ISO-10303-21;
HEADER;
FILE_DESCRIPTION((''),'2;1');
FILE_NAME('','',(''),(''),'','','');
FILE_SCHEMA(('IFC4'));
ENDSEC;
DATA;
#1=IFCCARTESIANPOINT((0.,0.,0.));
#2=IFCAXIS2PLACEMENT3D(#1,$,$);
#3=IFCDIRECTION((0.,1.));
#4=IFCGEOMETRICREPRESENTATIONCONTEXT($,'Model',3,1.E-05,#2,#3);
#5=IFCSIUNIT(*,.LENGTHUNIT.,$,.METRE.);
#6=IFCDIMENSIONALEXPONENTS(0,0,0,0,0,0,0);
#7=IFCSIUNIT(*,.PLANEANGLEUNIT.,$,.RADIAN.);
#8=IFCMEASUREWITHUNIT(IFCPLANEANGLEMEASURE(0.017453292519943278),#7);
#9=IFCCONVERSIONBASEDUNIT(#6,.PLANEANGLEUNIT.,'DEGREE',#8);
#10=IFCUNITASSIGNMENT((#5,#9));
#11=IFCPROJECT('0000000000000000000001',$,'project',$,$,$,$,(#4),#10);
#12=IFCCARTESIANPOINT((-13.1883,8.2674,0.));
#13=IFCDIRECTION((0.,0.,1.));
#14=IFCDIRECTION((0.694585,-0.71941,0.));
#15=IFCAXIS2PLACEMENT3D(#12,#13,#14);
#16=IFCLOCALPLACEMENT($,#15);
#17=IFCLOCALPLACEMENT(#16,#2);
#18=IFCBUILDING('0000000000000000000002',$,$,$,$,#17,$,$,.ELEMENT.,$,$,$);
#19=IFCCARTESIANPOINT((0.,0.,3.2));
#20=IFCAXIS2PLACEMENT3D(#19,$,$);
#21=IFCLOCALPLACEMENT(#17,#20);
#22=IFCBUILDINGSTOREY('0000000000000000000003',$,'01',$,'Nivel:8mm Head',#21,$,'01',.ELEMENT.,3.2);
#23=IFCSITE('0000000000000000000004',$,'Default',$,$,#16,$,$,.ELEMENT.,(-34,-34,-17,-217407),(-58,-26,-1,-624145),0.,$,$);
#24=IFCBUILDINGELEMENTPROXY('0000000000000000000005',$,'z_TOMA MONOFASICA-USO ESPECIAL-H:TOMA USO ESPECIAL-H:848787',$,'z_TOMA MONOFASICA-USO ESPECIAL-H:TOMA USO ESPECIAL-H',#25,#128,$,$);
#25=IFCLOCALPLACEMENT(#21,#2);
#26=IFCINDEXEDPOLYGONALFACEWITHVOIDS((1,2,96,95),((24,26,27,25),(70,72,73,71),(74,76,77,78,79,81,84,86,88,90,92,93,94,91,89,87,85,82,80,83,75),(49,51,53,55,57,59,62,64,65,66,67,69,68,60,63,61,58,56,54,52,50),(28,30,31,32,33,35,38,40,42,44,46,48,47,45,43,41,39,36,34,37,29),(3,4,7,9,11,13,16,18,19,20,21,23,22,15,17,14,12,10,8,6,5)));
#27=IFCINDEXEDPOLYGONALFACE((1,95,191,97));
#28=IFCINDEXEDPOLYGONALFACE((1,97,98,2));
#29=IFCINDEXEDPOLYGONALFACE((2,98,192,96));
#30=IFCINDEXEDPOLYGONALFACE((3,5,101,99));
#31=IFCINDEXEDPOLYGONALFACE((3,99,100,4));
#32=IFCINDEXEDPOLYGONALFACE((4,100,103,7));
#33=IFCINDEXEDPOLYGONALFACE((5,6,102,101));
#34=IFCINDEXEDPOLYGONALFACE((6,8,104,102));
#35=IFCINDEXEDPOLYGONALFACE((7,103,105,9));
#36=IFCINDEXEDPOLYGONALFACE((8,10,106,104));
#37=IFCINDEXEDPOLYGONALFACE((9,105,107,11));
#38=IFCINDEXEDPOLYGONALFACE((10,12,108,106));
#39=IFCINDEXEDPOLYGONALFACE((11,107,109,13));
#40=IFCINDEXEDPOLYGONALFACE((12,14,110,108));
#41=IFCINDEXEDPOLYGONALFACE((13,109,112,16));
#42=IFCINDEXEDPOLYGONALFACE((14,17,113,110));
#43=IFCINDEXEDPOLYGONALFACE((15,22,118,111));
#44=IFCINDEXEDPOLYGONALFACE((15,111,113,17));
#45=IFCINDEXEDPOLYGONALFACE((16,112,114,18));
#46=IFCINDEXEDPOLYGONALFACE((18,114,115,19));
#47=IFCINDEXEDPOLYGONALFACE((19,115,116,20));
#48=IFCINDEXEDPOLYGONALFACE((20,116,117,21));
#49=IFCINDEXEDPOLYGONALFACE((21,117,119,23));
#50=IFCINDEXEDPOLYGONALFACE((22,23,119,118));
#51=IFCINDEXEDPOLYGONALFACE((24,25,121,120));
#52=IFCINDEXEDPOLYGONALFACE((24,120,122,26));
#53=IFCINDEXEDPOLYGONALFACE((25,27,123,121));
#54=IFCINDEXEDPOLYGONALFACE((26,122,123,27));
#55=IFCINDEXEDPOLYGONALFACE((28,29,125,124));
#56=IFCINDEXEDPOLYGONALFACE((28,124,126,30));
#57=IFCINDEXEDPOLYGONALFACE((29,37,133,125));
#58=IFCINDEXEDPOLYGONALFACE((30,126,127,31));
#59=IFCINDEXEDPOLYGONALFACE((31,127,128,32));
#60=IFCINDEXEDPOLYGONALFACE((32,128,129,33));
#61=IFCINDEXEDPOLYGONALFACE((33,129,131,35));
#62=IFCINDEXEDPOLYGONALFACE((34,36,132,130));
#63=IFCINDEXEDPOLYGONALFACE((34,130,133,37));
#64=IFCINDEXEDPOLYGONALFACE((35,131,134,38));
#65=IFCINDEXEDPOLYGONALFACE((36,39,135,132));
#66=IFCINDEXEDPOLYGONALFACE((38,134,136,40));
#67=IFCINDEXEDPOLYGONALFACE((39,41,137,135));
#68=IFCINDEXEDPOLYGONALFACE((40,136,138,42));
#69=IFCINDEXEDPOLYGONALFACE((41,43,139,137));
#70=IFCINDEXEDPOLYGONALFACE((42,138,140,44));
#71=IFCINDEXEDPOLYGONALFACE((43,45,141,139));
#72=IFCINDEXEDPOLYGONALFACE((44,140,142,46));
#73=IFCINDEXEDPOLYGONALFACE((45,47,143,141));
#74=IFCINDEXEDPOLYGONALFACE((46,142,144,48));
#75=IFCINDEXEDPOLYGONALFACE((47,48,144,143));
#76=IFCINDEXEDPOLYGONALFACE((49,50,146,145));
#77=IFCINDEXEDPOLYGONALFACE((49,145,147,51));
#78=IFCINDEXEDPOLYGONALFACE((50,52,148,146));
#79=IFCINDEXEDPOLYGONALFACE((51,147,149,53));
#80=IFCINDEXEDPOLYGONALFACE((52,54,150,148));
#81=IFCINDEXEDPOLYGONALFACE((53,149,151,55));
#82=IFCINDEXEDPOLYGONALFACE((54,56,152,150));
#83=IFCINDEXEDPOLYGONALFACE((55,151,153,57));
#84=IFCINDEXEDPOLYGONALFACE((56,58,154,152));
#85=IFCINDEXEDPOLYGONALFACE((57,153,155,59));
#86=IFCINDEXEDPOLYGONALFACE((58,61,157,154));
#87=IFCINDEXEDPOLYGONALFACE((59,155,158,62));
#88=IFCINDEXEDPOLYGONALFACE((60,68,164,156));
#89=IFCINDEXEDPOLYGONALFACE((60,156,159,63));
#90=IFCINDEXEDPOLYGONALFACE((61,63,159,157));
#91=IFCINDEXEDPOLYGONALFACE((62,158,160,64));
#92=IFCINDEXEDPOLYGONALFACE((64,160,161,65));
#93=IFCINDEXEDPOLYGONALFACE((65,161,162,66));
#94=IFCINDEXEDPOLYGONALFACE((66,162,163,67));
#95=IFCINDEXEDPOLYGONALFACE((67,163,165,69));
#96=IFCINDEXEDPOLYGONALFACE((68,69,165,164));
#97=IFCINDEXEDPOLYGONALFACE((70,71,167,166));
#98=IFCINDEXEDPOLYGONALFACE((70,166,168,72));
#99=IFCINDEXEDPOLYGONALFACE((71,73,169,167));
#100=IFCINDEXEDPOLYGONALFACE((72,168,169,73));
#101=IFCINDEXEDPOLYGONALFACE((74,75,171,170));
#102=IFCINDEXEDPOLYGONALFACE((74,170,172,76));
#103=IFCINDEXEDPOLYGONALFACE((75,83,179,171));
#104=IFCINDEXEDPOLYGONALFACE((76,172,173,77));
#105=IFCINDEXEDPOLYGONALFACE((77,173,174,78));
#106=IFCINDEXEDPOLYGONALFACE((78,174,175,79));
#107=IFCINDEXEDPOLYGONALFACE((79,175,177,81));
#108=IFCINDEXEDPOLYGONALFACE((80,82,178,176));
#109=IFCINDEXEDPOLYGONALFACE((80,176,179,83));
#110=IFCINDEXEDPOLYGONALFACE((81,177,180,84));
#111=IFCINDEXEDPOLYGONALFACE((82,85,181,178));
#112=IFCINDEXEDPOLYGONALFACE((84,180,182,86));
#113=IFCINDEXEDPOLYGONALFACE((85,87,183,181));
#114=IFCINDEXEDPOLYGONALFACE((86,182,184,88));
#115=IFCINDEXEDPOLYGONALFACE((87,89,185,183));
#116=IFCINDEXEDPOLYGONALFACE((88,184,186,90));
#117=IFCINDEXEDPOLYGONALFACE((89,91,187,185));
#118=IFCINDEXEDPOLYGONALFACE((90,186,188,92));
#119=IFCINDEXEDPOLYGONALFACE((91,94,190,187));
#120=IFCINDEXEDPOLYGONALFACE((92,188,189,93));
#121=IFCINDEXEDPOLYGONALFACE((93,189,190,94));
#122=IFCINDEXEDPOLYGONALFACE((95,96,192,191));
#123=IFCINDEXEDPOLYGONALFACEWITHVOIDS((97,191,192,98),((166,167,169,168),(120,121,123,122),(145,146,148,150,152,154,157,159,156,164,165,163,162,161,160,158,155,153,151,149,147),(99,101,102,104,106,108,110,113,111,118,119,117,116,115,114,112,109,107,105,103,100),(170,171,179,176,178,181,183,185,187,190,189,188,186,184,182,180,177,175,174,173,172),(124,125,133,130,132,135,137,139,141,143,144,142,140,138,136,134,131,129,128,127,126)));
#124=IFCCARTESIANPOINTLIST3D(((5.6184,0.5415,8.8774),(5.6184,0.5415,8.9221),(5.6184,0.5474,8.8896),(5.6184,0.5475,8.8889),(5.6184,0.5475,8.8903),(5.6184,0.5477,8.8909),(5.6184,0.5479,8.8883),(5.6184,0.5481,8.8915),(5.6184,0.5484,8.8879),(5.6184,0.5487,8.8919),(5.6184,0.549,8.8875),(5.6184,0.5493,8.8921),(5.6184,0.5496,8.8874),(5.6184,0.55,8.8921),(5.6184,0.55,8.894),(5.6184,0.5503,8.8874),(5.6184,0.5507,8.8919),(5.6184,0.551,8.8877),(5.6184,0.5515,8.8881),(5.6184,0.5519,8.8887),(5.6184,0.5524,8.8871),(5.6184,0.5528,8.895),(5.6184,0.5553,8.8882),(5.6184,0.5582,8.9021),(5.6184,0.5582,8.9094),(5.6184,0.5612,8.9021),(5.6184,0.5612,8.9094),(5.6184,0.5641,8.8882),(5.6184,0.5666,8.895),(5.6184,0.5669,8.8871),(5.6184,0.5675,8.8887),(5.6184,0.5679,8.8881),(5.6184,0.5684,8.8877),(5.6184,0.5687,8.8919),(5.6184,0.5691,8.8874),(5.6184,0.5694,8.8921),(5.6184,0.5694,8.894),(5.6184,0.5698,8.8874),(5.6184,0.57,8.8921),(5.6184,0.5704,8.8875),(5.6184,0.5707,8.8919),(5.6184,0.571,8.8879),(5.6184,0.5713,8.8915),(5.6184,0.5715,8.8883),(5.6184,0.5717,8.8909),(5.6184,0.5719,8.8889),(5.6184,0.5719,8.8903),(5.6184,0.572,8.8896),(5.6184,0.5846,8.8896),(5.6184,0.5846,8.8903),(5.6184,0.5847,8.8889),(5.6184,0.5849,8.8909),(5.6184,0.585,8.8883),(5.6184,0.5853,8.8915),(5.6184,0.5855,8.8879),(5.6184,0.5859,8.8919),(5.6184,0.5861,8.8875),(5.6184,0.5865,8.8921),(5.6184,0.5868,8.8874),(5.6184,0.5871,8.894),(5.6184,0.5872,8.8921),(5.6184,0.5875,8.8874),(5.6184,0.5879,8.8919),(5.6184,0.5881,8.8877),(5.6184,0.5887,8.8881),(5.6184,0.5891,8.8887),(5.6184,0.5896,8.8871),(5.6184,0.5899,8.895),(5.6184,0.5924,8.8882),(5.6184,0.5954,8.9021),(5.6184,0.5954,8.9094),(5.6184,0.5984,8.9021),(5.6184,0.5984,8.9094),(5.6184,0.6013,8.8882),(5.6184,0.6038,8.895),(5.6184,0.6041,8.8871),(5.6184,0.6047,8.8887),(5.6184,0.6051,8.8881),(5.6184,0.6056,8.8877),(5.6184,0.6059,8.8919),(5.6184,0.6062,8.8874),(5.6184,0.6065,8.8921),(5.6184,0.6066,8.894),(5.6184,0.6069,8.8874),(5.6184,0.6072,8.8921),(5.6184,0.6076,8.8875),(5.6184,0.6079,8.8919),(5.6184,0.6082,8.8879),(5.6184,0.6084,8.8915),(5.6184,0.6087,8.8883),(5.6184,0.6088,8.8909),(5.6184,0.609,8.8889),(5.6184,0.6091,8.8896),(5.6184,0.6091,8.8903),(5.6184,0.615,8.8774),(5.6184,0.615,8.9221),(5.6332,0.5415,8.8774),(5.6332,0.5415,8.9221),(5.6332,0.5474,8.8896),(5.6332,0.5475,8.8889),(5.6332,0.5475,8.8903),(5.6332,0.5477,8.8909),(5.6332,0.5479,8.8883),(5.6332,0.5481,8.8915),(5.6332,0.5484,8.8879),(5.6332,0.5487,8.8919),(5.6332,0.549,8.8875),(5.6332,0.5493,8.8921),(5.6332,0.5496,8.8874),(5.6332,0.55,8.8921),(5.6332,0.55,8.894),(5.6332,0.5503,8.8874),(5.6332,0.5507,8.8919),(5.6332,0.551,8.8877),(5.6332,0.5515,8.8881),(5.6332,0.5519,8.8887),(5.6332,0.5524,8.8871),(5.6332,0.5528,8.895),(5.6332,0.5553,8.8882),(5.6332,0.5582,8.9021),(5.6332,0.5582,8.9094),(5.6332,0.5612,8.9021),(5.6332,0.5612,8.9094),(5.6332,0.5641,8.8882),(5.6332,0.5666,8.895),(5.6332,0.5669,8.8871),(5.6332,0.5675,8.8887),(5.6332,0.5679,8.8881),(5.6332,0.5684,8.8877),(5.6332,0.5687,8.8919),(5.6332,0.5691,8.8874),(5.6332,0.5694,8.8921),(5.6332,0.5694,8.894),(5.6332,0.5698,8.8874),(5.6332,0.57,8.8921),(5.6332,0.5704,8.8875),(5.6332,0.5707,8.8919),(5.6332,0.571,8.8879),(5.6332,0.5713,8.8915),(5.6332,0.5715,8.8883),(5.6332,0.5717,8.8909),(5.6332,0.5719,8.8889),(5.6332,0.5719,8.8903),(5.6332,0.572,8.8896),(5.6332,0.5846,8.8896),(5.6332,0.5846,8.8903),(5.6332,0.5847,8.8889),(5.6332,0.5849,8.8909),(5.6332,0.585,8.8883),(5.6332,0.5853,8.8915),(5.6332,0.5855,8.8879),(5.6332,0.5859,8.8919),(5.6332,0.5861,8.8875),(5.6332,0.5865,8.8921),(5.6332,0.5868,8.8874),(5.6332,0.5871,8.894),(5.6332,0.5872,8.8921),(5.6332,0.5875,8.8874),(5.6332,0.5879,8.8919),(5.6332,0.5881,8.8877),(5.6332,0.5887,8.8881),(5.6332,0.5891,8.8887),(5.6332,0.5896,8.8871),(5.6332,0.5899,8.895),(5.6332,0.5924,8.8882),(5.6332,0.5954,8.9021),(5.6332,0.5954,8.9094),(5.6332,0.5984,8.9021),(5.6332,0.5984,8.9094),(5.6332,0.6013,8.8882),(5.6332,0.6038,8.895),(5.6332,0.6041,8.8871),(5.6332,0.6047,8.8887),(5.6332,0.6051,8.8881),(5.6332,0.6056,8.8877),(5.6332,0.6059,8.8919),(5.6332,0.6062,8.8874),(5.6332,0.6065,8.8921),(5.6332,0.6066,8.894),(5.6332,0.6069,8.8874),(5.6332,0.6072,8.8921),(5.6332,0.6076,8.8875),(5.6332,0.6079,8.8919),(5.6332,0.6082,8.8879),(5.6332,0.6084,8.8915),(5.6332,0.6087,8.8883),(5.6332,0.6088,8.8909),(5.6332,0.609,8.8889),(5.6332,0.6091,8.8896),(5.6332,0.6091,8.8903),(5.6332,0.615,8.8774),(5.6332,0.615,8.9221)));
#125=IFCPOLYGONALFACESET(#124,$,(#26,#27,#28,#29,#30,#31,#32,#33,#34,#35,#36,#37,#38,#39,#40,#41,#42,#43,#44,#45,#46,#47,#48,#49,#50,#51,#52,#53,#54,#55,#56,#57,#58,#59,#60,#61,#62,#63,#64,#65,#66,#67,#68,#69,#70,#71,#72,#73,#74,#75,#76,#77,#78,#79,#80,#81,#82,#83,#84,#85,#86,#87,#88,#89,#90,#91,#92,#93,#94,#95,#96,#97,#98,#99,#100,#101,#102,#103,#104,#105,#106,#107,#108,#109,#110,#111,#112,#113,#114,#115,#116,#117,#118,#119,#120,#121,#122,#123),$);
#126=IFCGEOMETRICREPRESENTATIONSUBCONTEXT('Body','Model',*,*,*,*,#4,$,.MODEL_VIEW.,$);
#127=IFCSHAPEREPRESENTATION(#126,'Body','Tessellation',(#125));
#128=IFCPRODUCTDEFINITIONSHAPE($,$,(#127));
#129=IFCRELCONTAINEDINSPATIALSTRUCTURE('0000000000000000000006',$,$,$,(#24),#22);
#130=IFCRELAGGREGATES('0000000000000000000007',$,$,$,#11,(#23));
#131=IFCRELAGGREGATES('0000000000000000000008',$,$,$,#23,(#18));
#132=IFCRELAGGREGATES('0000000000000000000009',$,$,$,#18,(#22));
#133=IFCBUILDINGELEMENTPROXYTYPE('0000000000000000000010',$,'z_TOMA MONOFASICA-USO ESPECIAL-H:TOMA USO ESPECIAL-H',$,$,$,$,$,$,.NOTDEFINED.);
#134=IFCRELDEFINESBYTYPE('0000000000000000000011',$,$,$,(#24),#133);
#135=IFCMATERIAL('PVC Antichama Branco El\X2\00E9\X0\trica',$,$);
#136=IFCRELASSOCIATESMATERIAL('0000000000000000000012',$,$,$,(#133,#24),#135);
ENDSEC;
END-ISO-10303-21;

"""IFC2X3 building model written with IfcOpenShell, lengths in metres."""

from ifc_helpers import new_model, entity, si_unit, converted_unit, direction, frame, frame_2d, origin, place, context, subcontext, project, spatial, polyline, circle_curve, parameter, trimmed, segment, composite_curve, outline, extrude, source, transform, mapped, material, type_object, type_shapes, element, save


model = new_model("IFC2X3")

# Units and contexts
model_context = context("Model", 3, precision=1e-05, world=origin(), true_north=direction((0.0, 1.0)))
body_context = subcontext(model_context, "Body", "Model", "MODEL_VIEW")
ifc_project = project(units=[si_unit("LENGTHUNIT", "METRE"), converted_unit("PLANEANGLEUNIT", "DEGREE", entity("IfcPlaneAngleMeasure", 0.017453292519943278), si_unit("PLANEANGLEUNIT", "RADIAN"), dimensions=[0, 0, 0, 0, 0, 0, 0])], contexts=[model_context])

# Site, building, storey
site_placement = place(None, frame((-13.1883, 8.2674, 0.0), z_axis=(0.0, 0.0, 1.0), x_axis=(0.694585, -0.71941, 0.0)))
site = spatial("IfcSite", under=ifc_project, at=site_placement, Name="Default", CompositionType="ELEMENT", RefLatitude=(-34, -34, -17, -217407), RefLongitude=(-58, -26, -1, -624145), RefElevation=0.0)
building_placement = place(site_placement, origin())
building = spatial("IfcBuilding", under=site, at=building_placement, CompositionType="ELEMENT")
storey_placement = place(building_placement, frame((0.0, 0.0, 3.2)))
storey = spatial("IfcBuildingStorey", under=building, at=storey_placement, Name="01", ObjectType="Nivel:8mm Head", LongName="01", CompositionType="ELEMENT", Elevation=3.2)

# Building element proxy
ifc_material_1 = material(Name="PVC Antichama Branco Elétrica")
building_element_proxy_type_1 = type_object("IfcBuildingElementProxyType", Name="z_TOMA MONOFASICA-USO ESPECIAL-H:TOMA USO ESPECIAL-H", PredefinedType="NOTDEFINED", material=ifc_material_1)
shared_shape_1 = source(origin(), body_context, "Body", "SweptSolid", [
    extrude(outline(polyline([(-0.0368, -0.0223), (0.0368, -0.0223), (0.0368, 0.0223), (-0.0368, 0.0223), (-0.0368, -0.0223)]), holes=[composite_curve([segment(polyline([(0.0141, 0.0115), (0.0116, 0.0047)]), True, "CONTINUOUS"), segment(polyline([(0.0116, 0.0047), (0.0088, 0.0057)]), True, "CONTINUOUS"), segment(polyline([(0.0088, 0.0057), (0.0096, 0.0078)]), True, "CONTINUOUS"), segment(trimmed(circle_curve(frame_2d((0.0087, 0.0099), x_axis=(1.0, 0.0)), 0.0024), [parameter(27.118901)], [parameter(292.881099)], True, "PARAMETER"), False, "CONTINUOUS"), segment(polyline([(0.0108, 0.011), (0.0113, 0.0126)]), True, "CONTINUOUS"), segment(polyline([(0.0113, 0.0126), (0.0141, 0.0115)]), True, "CONTINUOUS")], self_intersect=False), composite_curve([segment(polyline([(0.0255, 0.0047), (0.023, 0.0115)]), True, "CONTINUOUS"), segment(polyline([(0.023, 0.0115), (0.0258, 0.0126)]), True, "CONTINUOUS"), segment(polyline([(0.0258, 0.0126), (0.0264, 0.011)]), True, "CONTINUOUS"), segment(trimmed(circle_curve(frame_2d((0.0285, 0.0099), x_axis=(1.0, 0.0)), 0.0024), [parameter(247.118901)], [parameter(152.881099)], True, "PARAMETER"), False, "CONTINUOUS"), segment(polyline([(0.0276, 0.0078), (0.0283, 0.0057)]), True, "CONTINUOUS"), segment(polyline([(0.0283, 0.0057), (0.0255, 0.0047)]), True, "CONTINUOUS")], self_intersect=False), polyline([(0.0201, -0.0024), (0.0201, -0.0097), (0.0171, -0.0097), (0.0171, -0.0024), (0.0201, -0.0024)]), composite_curve([segment(polyline([(-0.0141, 0.0115), (-0.0113, 0.0126)]), True, "CONTINUOUS"), segment(polyline([(-0.0113, 0.0126), (-0.0108, 0.011)]), True, "CONTINUOUS"), segment(trimmed(circle_curve(frame_2d((-0.0087, 0.0099), x_axis=(1.0, 0.0)), 0.0024), [parameter(247.118901)], [parameter(152.881099)], True, "PARAMETER"), False, "CONTINUOUS"), segment(polyline([(-0.0096, 0.0078), (-0.0088, 0.0057)]), True, "CONTINUOUS"), segment(polyline([(-0.0088, 0.0057), (-0.0116, 0.0047)]), True, "CONTINUOUS"), segment(polyline([(-0.0116, 0.0047), (-0.0141, 0.0115)]), True, "CONTINUOUS")], self_intersect=False), composite_curve([segment(polyline([(-0.0255, 0.0047), (-0.0283, 0.0057)]), True, "CONTINUOUS"), segment(polyline([(-0.0283, 0.0057), (-0.0276, 0.0078)]), True, "CONTINUOUS"), segment(trimmed(circle_curve(frame_2d((-0.0285, 0.0099), x_axis=(1.0, 0.0)), 0.0024), [parameter(27.118901)], [parameter(292.881099)], True, "PARAMETER"), False, "CONTINUOUS"), segment(polyline([(-0.0264, 0.011), (-0.0258, 0.0126)]), True, "CONTINUOUS"), segment(polyline([(-0.0258, 0.0126), (-0.023, 0.0115)]), True, "CONTINUOUS"), segment(polyline([(-0.023, 0.0115), (-0.0255, 0.0047)]), True, "CONTINUOUS")], self_intersect=False), polyline([(-0.0201, -0.0024), (-0.0171, -0.0024), (-0.0171, -0.0097), (-0.0201, -0.0097), (-0.0201, -0.0024)])]), frame((0.0, -0.005, 0.0223), z_axis=(0.0, 1.0, 0.0), x_axis=(1.0, 0.0, 0.0)), (0.0, 0.0, 1.0), 0.0148),
])
type_shapes(building_element_proxy_type_1, [shared_shape_1])
for number, where, z_axis, x_axis, name in (
    (1, (5.6282, 0.5783, 8.8774), (0.0, 0.0, 1.0), (0.0, 1.0, 0.0), "z_TOMA MONOFASICA-USO ESPECIAL-H:TOMA USO ESPECIAL-H:848787"),
):
    element("IfcBuildingElementProxy", number, at=place(storey_placement, frame(where, z_axis=z_axis, x_axis=x_axis)), inside=storey, type_object=building_element_proxy_type_1, material=ifc_material_1, Name=name, ObjectType="z_TOMA MONOFASICA-USO ESPECIAL-H:TOMA USO ESPECIAL-H", context=body_context, shape_type="MappedRepresentation", body=[
        mapped(shared_shape_1, transform((0.0, 0.0, 0.0), scale=1.0)),
    ])

save(model, "model.ifc")
